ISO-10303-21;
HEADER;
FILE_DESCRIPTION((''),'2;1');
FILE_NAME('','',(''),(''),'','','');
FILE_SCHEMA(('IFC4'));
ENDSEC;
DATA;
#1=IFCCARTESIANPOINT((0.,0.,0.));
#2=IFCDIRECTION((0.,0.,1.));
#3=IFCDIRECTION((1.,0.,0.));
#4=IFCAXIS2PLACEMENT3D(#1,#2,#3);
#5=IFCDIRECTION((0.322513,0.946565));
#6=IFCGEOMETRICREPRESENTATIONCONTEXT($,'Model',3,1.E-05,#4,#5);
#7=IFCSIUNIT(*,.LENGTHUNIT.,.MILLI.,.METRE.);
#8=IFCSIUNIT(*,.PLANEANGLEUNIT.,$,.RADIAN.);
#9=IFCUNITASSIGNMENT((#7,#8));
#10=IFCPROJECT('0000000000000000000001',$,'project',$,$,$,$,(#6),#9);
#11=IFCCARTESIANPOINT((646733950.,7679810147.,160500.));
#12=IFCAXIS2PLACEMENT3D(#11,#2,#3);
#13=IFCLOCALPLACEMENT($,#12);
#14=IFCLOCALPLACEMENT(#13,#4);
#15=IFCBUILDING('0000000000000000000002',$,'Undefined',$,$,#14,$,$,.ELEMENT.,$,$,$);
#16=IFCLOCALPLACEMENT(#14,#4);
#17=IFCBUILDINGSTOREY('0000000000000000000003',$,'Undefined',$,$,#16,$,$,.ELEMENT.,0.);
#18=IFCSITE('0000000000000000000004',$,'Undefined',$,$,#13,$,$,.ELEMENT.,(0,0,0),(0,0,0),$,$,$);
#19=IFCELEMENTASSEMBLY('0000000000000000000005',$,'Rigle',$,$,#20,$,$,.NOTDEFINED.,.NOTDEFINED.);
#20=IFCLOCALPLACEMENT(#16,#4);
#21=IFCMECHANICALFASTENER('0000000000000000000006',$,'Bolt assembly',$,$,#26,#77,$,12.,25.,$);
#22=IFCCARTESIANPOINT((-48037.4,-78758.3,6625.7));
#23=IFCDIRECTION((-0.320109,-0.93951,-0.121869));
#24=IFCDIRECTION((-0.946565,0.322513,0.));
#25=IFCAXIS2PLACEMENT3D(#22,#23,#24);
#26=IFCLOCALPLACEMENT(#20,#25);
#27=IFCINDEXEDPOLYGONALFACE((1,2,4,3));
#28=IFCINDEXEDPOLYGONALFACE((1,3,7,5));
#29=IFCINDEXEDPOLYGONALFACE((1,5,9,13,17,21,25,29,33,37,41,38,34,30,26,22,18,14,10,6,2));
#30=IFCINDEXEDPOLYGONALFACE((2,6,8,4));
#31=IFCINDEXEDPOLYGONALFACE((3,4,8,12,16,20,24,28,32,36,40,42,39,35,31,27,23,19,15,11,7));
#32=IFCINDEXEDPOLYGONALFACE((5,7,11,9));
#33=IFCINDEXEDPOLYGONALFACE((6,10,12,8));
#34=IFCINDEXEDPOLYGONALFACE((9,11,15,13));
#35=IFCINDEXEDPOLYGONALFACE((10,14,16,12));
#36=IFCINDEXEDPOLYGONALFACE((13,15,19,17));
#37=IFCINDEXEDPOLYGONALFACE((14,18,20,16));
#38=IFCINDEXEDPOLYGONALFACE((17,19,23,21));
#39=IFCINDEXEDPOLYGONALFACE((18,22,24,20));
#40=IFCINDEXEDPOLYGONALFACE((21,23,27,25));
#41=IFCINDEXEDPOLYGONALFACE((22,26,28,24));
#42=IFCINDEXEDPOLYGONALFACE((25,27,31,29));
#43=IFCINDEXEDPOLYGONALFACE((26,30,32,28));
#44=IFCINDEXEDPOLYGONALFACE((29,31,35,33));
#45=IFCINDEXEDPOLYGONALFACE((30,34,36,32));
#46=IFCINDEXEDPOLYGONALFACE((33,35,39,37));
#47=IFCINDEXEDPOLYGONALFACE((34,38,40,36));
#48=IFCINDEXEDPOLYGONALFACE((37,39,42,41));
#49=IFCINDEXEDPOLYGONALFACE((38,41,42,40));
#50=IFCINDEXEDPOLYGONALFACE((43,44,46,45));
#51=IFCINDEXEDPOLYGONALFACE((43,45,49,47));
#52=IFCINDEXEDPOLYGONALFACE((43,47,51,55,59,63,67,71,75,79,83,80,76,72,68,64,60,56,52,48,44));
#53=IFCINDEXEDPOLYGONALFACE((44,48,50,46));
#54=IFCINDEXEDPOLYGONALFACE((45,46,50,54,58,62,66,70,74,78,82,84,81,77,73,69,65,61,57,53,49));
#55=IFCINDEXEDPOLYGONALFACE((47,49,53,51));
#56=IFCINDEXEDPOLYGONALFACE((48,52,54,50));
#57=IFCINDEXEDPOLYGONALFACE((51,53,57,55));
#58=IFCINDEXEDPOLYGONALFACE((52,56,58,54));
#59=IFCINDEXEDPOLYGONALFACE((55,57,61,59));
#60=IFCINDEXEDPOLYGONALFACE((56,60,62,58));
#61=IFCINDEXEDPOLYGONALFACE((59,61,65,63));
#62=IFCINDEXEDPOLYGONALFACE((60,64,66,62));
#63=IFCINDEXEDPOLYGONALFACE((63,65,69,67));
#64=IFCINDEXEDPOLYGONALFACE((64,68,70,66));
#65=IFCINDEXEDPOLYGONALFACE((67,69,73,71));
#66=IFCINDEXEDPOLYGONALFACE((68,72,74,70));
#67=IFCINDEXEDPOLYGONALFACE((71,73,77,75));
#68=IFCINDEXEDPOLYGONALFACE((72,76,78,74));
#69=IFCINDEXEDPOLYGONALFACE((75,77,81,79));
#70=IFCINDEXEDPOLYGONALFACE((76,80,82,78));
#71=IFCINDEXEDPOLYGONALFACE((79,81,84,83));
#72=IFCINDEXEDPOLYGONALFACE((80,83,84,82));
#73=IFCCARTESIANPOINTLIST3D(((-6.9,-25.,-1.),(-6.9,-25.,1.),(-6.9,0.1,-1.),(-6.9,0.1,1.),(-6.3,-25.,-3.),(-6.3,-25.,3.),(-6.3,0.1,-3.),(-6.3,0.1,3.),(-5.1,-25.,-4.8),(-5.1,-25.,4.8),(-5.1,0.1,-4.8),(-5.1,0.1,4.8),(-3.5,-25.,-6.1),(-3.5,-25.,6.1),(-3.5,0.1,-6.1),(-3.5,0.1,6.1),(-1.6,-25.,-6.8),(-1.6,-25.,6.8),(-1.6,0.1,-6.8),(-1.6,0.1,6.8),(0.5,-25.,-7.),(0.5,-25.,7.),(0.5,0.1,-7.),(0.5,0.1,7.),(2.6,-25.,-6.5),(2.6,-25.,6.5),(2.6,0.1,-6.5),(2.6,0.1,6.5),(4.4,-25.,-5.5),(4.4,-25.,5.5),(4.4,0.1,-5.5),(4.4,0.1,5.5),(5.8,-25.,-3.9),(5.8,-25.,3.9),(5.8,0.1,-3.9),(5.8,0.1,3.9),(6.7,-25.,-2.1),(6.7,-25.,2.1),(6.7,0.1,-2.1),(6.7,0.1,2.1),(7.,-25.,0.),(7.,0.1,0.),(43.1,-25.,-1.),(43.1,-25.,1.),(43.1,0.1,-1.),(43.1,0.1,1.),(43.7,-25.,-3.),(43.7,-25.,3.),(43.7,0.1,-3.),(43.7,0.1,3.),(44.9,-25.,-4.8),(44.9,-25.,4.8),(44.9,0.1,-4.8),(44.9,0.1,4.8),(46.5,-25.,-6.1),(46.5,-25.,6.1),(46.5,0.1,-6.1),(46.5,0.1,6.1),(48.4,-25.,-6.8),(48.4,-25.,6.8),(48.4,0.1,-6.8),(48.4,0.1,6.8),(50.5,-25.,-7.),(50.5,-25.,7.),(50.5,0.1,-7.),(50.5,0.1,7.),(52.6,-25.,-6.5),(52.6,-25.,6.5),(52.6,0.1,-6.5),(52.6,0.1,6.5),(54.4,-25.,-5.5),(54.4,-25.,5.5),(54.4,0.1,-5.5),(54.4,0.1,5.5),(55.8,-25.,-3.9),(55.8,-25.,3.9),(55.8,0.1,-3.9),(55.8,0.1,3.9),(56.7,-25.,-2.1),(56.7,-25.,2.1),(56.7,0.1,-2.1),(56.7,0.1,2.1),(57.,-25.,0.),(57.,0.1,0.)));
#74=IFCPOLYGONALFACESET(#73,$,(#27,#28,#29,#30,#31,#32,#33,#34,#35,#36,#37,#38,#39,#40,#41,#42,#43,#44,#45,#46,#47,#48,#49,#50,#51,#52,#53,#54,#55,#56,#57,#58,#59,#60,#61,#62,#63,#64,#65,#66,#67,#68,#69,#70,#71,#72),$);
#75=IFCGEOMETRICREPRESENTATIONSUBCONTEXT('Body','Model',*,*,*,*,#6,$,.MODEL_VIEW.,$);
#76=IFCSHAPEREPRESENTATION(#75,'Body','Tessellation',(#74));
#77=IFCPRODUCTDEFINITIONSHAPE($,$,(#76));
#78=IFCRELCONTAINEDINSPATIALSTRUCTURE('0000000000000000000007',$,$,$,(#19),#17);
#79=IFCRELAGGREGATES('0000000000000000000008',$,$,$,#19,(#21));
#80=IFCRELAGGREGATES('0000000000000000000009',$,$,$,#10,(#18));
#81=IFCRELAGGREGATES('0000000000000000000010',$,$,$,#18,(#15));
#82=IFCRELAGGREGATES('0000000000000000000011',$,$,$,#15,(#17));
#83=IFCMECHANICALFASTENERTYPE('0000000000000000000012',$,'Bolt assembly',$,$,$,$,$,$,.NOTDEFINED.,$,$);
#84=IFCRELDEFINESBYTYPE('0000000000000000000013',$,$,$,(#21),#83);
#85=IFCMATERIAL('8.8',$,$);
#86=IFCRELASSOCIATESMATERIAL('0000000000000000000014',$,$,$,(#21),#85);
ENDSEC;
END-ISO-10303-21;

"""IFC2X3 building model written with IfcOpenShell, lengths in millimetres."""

from ifc_helpers import new_model, si_unit, direction, frame, origin_with_axes, origin_2d_with_axis, place, context, subcontext, project, spatial, circle, extrude, source, transform, mapped, material, type_object, element, aggregate, save


model = new_model("IFC2X3")

# Units and contexts
model_context = context("Model", 3, precision=1e-05, world=origin_with_axes(), true_north=direction((0.322513, 0.946565)))
body_context = subcontext(model_context, "Body", "Model", "MODEL_VIEW")
ifc_project = project(units=[si_unit("LENGTHUNIT", "METRE", prefix="MILLI"), si_unit("PLANEANGLEUNIT", "RADIAN")], contexts=[model_context])

# Site, building, storey
site_placement = place(None, frame((646733950.0, 7679810147.0, 160500.0), z_axis=(0.0, 0.0, 1.0), x_axis=(1.0, 0.0, 0.0)))
site = spatial("IfcSite", under=ifc_project, at=site_placement, Name="Undefined", CompositionType="ELEMENT", RefLatitude=(0, 0, 0), RefLongitude=(0, 0, 0))
building_placement = place(site_placement, origin_with_axes())
building = spatial("IfcBuilding", under=site, at=building_placement, Name="Undefined", CompositionType="ELEMENT")
storey_placement = place(building_placement, origin_with_axes())
storey = spatial("IfcBuildingStorey", under=building, at=storey_placement, Name="Undefined", CompositionType="ELEMENT", Elevation=0.0)

# Element assembly
assembly_1_placement = place(storey_placement, origin_with_axes())
assembly_1 = element("IfcElementAssembly", 1, at=assembly_1_placement, inside=storey, Name="Rigle", AssemblyPlace="NOTDEFINED", PredefinedType="NOTDEFINED")

# Mechanical fastener
ifc_material_1 = material(Name="8.8")
mechanical_fastener_type = type_object("IfcMechanicalFastenerType", Name="Bolt assembly")
shared_shape_1 = source(origin_with_axes(), body_context, "Body", "SweptSolid", [
    extrude(circle(Radius=7.0, at=origin_2d_with_axis()), frame((0.0, -25.0, 0.0), z_axis=(0.0, 1.0, 0.0), x_axis=(1.0, 0.0, 0.0)), (0.0, 0.0, 1.0), 25.1),
])
mechanical_fastener_1_placement = place(assembly_1_placement, frame((-48037.4, -78758.3, 6625.7), z_axis=(-0.320109, -0.93951, -0.121869), x_axis=(-0.946565, 0.322513, 0.0)))
mechanical_fastener_1 = element("IfcMechanicalFastener", 2, at=mechanical_fastener_1_placement, type_object=mechanical_fastener_type, material=ifc_material_1, Name="Bolt assembly", NominalDiameter=12.0, NominalLength=25.0, context=body_context, shape_type="MappedRepresentation", body=[
    mapped(shared_shape_1, transform((0.0, 0.0, 0.0))),
    mapped(shared_shape_1, transform((50.0, 0.0, 0.0))),
])
aggregate(assembly_1, [mechanical_fastener_1])

save(model, "model.ifc")
